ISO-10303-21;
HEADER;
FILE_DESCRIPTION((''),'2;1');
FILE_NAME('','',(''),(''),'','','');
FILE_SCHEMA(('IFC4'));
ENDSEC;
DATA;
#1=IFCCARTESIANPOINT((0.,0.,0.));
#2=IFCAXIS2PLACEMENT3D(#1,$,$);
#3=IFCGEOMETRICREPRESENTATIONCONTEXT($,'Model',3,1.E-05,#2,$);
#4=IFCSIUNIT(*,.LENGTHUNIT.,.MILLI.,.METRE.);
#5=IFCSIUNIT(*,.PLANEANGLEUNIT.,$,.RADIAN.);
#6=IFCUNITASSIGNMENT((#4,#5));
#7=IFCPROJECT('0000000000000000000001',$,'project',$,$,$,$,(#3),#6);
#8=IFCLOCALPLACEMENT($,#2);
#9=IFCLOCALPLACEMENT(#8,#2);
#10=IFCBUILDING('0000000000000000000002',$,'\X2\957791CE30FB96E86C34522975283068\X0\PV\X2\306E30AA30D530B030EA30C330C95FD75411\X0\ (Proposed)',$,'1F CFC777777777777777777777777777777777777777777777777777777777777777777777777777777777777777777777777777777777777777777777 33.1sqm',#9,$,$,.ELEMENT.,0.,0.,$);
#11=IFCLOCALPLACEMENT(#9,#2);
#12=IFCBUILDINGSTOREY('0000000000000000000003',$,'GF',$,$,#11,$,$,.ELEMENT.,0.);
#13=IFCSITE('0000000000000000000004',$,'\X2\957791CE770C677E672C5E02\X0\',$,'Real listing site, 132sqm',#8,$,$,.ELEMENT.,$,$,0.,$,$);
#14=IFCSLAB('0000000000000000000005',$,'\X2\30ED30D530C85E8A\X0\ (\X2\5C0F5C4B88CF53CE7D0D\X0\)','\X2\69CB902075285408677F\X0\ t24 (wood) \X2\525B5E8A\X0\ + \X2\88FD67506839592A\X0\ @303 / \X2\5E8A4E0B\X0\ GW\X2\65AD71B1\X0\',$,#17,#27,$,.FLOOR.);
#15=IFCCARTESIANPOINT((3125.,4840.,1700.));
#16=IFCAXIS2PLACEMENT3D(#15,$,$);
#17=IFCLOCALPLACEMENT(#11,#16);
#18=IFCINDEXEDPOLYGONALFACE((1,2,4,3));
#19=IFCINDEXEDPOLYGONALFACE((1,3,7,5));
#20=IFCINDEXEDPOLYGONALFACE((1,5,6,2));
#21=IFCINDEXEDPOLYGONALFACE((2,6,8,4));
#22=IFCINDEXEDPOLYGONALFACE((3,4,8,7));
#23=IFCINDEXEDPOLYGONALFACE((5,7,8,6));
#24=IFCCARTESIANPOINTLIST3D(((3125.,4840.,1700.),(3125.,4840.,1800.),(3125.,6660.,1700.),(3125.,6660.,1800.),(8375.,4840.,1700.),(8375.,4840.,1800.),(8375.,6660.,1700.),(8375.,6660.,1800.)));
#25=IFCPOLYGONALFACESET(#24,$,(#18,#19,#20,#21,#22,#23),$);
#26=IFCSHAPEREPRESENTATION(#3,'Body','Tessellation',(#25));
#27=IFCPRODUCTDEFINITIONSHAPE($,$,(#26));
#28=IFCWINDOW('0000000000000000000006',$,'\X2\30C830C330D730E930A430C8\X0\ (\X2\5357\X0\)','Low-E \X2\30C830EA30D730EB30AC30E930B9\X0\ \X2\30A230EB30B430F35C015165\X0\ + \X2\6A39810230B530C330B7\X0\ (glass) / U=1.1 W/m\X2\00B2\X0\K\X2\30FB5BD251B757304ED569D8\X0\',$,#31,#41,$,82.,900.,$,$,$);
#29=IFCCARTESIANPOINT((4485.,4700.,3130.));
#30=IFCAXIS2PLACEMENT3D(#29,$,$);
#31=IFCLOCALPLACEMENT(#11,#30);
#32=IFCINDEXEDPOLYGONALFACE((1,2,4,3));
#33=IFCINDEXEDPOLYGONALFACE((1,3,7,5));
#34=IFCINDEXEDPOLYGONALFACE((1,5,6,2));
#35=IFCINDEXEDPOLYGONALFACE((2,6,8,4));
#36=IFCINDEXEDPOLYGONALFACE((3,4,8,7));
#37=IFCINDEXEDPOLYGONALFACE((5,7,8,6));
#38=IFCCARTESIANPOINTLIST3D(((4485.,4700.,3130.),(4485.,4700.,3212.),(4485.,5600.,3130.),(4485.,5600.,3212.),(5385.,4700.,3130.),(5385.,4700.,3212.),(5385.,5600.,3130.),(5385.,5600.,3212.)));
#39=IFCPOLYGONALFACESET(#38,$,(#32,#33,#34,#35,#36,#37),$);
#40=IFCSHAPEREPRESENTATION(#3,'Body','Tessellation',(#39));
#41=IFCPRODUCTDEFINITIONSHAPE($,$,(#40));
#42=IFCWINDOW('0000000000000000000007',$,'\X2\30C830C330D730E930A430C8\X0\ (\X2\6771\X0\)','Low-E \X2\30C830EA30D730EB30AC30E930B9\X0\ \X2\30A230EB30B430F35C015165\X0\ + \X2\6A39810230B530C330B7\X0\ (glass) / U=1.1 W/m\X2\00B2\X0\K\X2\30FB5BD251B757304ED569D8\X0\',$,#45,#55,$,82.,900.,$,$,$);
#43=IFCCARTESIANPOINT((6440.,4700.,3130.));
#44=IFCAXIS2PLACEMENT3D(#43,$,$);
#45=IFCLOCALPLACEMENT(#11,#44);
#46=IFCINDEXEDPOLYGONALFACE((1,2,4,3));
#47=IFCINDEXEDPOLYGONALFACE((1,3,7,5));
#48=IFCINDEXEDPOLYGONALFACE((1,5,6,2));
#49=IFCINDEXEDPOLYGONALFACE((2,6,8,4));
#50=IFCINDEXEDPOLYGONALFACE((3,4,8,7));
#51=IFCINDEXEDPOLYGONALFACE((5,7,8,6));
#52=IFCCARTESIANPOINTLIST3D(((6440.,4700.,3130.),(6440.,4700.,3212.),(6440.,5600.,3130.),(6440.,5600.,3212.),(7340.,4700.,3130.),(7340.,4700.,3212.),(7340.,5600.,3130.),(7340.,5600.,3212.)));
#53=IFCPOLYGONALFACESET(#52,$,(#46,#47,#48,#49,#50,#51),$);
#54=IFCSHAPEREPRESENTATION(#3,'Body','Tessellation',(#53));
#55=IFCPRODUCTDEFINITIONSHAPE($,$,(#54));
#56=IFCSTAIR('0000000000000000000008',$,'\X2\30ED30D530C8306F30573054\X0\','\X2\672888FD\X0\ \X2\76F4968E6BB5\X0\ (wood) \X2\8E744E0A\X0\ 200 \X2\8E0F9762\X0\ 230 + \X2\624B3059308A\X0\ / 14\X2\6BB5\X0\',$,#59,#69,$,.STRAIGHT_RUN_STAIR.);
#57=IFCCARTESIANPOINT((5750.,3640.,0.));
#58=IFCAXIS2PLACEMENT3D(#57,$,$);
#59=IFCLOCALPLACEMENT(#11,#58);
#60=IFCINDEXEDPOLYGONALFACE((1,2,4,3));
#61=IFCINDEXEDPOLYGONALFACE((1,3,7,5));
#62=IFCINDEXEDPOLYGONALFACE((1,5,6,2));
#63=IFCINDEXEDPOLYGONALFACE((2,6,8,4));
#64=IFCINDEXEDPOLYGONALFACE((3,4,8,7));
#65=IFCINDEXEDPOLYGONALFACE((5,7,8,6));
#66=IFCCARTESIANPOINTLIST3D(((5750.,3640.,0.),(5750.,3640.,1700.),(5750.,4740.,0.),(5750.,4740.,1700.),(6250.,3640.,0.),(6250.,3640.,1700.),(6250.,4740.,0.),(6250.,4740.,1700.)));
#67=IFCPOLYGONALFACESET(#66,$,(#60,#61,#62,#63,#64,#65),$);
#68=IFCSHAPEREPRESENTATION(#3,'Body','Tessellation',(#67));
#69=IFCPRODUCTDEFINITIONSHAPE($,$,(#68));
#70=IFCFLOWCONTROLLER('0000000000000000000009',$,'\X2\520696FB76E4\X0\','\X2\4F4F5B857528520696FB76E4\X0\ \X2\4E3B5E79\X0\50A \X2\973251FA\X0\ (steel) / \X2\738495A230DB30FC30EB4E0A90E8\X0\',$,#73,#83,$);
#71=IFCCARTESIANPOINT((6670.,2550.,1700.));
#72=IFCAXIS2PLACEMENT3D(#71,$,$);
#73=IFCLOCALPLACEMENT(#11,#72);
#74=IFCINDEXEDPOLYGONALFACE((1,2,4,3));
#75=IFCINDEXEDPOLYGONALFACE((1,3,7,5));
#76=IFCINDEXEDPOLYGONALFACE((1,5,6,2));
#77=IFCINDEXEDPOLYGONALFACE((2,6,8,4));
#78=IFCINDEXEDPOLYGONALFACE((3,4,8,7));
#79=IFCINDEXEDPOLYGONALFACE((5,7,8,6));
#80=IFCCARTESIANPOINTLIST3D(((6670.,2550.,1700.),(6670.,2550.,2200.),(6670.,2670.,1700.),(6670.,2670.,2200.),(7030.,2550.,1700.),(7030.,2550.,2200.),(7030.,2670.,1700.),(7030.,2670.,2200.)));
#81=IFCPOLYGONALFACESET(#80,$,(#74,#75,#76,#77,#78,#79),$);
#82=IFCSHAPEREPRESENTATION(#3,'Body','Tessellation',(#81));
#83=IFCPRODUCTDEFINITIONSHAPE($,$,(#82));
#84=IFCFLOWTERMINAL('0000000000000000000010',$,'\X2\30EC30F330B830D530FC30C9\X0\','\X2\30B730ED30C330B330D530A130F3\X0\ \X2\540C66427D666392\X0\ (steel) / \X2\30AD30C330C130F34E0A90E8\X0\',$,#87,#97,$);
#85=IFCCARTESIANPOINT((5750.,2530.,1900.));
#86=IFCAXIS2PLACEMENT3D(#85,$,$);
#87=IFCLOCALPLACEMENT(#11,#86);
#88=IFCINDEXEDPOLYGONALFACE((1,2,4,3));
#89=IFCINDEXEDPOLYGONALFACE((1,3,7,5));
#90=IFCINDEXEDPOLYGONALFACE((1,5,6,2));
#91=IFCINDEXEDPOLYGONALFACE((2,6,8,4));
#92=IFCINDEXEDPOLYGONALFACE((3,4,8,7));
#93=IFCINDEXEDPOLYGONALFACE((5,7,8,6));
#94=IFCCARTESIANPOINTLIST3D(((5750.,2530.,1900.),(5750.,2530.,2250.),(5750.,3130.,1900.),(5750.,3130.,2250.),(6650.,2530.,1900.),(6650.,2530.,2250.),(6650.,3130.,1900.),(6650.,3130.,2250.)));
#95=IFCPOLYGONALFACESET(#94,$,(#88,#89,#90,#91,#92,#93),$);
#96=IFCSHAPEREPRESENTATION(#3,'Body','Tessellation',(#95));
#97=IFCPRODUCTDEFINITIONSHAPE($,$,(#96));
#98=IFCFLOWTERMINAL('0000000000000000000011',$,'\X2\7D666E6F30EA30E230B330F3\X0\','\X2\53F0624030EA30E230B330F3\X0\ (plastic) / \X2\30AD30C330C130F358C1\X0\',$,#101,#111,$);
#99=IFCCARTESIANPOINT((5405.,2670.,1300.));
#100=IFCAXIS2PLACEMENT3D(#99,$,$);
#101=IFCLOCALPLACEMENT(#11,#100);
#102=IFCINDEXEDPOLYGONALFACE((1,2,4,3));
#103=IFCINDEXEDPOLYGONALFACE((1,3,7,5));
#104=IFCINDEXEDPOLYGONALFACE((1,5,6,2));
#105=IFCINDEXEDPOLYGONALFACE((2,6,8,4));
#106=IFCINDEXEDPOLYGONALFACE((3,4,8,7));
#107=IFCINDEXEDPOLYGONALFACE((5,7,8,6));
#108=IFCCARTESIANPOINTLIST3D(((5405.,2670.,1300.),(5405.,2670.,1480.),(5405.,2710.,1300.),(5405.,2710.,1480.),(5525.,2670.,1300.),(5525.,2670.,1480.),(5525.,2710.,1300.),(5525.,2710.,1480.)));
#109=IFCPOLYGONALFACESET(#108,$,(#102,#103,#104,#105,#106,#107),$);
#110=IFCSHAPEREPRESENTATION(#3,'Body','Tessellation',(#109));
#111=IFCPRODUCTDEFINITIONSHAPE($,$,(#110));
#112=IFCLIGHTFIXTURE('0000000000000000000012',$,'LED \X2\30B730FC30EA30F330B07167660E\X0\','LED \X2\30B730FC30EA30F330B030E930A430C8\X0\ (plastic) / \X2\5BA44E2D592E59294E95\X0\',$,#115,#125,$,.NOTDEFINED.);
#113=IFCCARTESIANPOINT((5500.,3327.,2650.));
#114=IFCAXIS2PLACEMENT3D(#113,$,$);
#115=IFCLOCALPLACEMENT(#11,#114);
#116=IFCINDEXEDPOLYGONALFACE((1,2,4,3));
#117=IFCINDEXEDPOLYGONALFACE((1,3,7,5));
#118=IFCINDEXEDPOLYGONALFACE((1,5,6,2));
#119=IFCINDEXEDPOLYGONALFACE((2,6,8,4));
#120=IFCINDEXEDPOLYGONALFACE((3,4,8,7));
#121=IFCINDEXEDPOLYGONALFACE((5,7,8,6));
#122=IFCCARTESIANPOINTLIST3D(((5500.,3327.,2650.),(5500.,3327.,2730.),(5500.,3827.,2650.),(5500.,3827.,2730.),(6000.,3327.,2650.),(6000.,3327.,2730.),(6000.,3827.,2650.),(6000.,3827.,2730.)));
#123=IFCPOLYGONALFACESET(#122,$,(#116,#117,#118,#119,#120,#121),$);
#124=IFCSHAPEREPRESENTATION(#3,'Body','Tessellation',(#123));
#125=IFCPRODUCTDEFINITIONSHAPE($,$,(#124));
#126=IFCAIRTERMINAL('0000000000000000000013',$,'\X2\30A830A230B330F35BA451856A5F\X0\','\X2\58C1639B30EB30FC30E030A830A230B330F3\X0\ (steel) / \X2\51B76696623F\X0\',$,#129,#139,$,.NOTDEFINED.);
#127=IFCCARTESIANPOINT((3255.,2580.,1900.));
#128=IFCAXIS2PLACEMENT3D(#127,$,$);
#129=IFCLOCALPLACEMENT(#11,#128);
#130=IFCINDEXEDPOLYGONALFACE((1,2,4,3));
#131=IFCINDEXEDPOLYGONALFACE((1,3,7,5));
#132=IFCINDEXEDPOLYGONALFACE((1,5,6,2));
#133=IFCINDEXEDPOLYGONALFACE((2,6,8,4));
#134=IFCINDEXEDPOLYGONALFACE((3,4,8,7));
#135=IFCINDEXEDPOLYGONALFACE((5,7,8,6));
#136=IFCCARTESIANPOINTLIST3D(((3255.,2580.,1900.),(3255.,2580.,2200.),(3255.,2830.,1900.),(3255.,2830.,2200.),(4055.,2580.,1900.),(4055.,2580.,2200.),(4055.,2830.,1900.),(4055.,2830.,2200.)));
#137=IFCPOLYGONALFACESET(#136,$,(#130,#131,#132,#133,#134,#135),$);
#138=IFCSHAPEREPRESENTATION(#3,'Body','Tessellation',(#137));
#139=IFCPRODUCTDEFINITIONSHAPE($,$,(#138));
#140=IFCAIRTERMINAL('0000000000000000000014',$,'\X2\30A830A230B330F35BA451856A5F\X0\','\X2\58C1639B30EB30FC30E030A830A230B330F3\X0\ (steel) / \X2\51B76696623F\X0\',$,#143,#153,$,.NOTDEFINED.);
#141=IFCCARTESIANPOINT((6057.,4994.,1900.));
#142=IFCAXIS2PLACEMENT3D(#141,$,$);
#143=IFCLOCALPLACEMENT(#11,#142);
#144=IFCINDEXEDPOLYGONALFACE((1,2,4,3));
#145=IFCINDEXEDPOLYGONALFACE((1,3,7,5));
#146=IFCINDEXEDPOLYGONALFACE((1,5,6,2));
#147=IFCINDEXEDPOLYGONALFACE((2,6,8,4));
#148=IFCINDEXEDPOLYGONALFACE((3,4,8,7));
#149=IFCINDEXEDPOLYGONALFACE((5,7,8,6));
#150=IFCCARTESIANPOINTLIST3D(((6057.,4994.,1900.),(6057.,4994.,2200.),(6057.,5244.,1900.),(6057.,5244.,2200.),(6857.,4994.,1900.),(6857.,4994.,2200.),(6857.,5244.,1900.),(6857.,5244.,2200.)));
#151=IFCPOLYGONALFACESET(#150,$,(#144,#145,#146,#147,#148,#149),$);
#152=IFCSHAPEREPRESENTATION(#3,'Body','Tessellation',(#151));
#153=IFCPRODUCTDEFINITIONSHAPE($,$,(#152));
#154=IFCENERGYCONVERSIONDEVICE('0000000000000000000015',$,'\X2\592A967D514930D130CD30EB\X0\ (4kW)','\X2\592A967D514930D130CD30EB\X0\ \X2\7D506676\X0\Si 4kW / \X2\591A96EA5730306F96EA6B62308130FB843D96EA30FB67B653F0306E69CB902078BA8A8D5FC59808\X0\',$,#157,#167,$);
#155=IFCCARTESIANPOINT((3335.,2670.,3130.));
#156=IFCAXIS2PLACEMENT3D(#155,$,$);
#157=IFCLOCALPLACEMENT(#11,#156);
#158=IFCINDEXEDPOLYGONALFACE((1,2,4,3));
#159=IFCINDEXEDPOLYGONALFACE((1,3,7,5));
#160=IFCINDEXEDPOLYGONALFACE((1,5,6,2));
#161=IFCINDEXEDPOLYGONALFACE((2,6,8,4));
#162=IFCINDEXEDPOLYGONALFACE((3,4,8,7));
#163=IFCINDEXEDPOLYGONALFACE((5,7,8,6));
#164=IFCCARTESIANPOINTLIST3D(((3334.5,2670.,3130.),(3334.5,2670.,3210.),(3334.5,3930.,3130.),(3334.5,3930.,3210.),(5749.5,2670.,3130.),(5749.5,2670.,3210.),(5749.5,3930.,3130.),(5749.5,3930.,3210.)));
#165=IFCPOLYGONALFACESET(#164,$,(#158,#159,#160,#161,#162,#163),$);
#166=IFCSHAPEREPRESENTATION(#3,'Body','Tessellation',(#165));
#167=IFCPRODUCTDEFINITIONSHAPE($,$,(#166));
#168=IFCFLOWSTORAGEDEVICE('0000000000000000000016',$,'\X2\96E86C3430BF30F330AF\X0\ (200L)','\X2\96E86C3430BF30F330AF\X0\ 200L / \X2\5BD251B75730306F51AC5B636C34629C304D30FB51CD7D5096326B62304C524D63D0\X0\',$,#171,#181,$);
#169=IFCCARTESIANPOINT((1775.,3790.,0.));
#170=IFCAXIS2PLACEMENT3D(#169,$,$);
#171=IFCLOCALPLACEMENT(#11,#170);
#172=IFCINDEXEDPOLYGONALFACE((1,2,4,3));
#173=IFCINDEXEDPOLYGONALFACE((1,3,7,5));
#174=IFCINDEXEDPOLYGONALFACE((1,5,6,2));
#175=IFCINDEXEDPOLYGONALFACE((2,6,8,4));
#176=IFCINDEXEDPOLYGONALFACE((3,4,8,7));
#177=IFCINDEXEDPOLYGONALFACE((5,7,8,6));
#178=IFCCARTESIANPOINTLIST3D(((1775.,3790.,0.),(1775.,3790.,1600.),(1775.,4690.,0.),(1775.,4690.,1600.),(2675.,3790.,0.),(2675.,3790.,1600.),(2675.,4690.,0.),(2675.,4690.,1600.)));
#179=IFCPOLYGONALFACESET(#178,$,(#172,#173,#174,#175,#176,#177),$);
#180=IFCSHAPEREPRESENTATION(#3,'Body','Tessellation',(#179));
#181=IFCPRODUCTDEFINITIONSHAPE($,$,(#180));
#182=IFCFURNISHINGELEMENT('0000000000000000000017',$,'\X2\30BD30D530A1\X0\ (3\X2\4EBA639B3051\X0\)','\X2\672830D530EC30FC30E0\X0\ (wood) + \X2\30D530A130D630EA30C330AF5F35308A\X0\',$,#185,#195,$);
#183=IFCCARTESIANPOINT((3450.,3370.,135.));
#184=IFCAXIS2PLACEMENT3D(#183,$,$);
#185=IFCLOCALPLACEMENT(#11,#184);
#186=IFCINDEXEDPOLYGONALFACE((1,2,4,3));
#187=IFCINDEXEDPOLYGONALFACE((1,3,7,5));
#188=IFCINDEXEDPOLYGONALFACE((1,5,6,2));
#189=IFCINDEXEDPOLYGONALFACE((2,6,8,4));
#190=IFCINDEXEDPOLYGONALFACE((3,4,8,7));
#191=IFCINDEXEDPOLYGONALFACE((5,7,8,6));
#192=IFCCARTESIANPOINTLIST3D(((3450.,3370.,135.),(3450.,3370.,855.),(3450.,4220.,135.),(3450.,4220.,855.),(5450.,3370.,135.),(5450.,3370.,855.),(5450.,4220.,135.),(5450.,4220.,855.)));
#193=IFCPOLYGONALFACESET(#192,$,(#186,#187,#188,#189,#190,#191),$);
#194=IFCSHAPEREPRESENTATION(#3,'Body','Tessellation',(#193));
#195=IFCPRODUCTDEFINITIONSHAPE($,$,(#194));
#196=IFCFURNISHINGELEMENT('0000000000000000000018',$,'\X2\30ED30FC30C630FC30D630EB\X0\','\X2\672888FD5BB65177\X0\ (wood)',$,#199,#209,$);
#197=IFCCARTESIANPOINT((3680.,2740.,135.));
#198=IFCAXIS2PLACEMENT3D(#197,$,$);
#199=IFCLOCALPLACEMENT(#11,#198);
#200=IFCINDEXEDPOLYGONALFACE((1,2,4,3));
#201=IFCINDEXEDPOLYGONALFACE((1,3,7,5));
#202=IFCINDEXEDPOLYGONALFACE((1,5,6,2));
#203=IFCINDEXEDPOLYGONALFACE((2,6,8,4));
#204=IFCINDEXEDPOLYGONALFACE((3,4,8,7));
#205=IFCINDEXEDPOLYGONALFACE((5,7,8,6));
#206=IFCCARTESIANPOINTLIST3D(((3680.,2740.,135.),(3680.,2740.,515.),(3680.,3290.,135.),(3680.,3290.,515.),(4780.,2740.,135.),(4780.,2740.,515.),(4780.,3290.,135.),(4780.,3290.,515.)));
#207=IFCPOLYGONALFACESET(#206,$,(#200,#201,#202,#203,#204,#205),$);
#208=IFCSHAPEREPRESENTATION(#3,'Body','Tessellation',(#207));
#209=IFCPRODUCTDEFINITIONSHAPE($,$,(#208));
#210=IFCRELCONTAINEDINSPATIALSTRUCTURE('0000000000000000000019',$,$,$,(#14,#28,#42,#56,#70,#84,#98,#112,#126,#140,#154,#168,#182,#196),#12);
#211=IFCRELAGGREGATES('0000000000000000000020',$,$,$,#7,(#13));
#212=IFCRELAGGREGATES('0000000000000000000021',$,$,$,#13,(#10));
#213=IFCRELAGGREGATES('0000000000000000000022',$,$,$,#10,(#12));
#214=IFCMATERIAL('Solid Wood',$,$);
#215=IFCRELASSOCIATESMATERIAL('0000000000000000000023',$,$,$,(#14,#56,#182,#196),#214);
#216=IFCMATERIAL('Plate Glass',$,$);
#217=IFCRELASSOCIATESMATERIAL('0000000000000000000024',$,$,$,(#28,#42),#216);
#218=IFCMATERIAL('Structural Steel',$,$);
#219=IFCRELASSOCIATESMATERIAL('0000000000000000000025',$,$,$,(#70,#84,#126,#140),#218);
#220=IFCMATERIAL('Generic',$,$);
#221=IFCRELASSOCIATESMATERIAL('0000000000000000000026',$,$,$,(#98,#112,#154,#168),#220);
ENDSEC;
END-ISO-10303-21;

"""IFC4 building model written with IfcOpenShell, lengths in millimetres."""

from ifc_helpers import new_model, si_unit, frame, frame_2d, origin, place, context, project, spatial, rectangle, extrude, material, element, save


model = new_model("IFC4")

# Units and contexts
model_context = context("Model", 3, precision=1e-05, world=origin())
ifc_project = project(units=[si_unit("LENGTHUNIT", "METRE", prefix="MILLI"), si_unit("PLANEANGLEUNIT", "RADIAN")], contexts=[model_context])

# Site, building, storey
site_placement = place(None, origin())
site = spatial("IfcSite", under=ifc_project, at=site_placement, Name="長野県松本市", ObjectType="Real listing site, 132sqm", CompositionType="ELEMENT", RefElevation=0.0)
building_placement = place(site_placement, origin())
building = spatial("IfcBuilding", under=site, at=building_placement, Name="長野・雨水利用とPVのオフグリッド志向 (Proposed)", ObjectType="1F CFC777777777777777777777777777777777777777777777777777777777777777777777777777777777777777777777777777777777777777777777 33.1sqm", CompositionType="ELEMENT", ElevationOfRefHeight=0.0, ElevationOfTerrain=0.0)
storey_placement = place(building_placement, origin())
storey = spatial("IfcBuildingStorey", under=building, at=storey_placement, Name="GF", CompositionType="ELEMENT", Elevation=0.0)

# Shared definitions
ifc_material_1 = material(Name="Solid Wood")

# Slab
slab_placement = place(storey_placement, frame((3125.0, 4840.0, 1700.0)))
element("IfcSlab", 1, at=slab_placement, inside=storey, material=ifc_material_1, Name="ロフト床 (小屋裏収納)", Description="構造用合板 t24 (wood) 剛床 + 製材根太 @303 / 床下 GW断熱", PredefinedType="FLOOR", context=model_context, shape_type="SweptSolid", body=[
    extrude(rectangle(XDim=5250.0, YDim=1820.0, at=frame_2d((2625.0, 910.0))), frame((3125.0, 4840.0, 1700.0)), (0.0, 0.0, 1.0), 100.0),
])

# Windows
ifc_material_2 = material(Name="Plate Glass")
window_1_placement = place(storey_placement, frame((4485.0, 4700.0, 3130.0)))
element("IfcWindow", 2, at=window_1_placement, inside=storey, material=ifc_material_2, Name="トップライト (南)", Description="Low-E トリプルガラス アルゴン封入 + 樹脂サッシ (glass) / U=1.1 W/m²K・寒冷地仕様", OverallHeight=82.0, OverallWidth=900.0, context=model_context, shape_type="SweptSolid", body=[
    extrude(rectangle(XDim=900.0, YDim=900.0, at=frame_2d((450.0, 450.0))), frame((4485.0, 4700.0, 3130.0)), (0.0, 0.0, 1.0), 82.0),
])
window_2_placement = place(storey_placement, frame((6440.0, 4700.0, 3130.0)))
element("IfcWindow", 3, at=window_2_placement, inside=storey, material=ifc_material_2, Name="トップライト (東)", Description="Low-E トリプルガラス アルゴン封入 + 樹脂サッシ (glass) / U=1.1 W/m²K・寒冷地仕様", OverallHeight=82.0, OverallWidth=900.0, context=model_context, shape_type="SweptSolid", body=[
    extrude(rectangle(XDim=900.0, YDim=900.0, at=frame_2d((450.0, 450.0))), frame((6440.0, 4700.0, 3130.0)), (0.0, 0.0, 1.0), 82.0),
])

# Stair
stair_placement = place(storey_placement, frame((5750.0, 3640.0, 0.0)))
element("IfcStair", 4, at=stair_placement, inside=storey, material=ifc_material_1, Name="ロフトはしご", Description="木製 直階段 (wood) 蹴上 200 踏面 230 + 手すり / 14段", PredefinedType="STRAIGHT_RUN_STAIR", context=model_context, shape_type="SweptSolid", body=[
    extrude(rectangle(XDim=500.0, YDim=1100.0, at=frame_2d((250.0, 550.0))), frame((5750.0, 3640.0, 0.0)), (0.0, 0.0, 1.0), 1700.0),
])

# Flow controller
ifc_material_3 = material(Name="Structural Steel")
flow_controller_placement = place(storey_placement, frame((6670.0, 2550.0, 1700.0)))
element("IfcFlowController", 5, at=flow_controller_placement, inside=storey, material=ifc_material_3, Name="分電盤", Description="住宅用分電盤 主幹50A 露出 (steel) / 玄関ホール上部", context=model_context, shape_type="SweptSolid", body=[
    extrude(rectangle(XDim=360.0, YDim=120.0, at=frame_2d((180.0, 60.0))), frame((6670.0, 2550.0, 1700.0)), (0.0, 0.0, 1.0), 500.0),
])

# Flow terminals
flow_terminal_1_placement = place(storey_placement, frame((5750.0, 2530.0, 1900.0)))
element("IfcFlowTerminal", 6, at=flow_terminal_1_placement, inside=storey, material=ifc_material_3, Name="レンジフード", Description="シロッコファン 同時給排 (steel) / キッチン上部", context=model_context, shape_type="SweptSolid", body=[
    extrude(rectangle(XDim=900.0, YDim=600.0, at=frame_2d((450.0, 300.0))), frame((5750.0, 2530.0, 1900.0)), (0.0, 0.0, 1.0), 350.0),
])
ifc_material_4 = material(Name="Generic")
flow_terminal_2_placement = place(storey_placement, frame((5405.0, 2670.0, 1300.0)))
element("IfcFlowTerminal", 7, at=flow_terminal_2_placement, inside=storey, material=ifc_material_4, Name="給湯リモコン", Description="台所リモコン (plastic) / キッチン壁", context=model_context, shape_type="SweptSolid", body=[
    extrude(rectangle(XDim=120.0, YDim=40.0, at=frame_2d((60.0, 20.0))), frame((5405.0, 2670.0, 1300.0)), (0.0, 0.0, 1.0), 180.0),
])

# Light fixture
light_fixture_placement = place(storey_placement, frame((5500.0, 3327.0, 2650.0)))
element("IfcLightFixture", 8, at=light_fixture_placement, inside=storey, material=ifc_material_4, Name="LED シーリング照明", Description="LED シーリングライト (plastic) / 室中央天井", PredefinedType="NOTDEFINED", context=model_context, shape_type="SweptSolid", body=[
    extrude(rectangle(XDim=500.0, YDim=500.0, at=frame_2d((250.0, 250.0))), frame((5500.0, 3327.0, 2650.0)), (0.0, 0.0, 1.0), 80.0),
])

# Air terminals
air_terminal_1_placement = place(storey_placement, frame((3255.0, 2580.0, 1900.0)))
element("IfcAirTerminal", 9, at=air_terminal_1_placement, inside=storey, material=ifc_material_3, Name="エアコン室内機", Description="壁掛ルームエアコン (steel) / 冷暖房", PredefinedType="NOTDEFINED", context=model_context, shape_type="SweptSolid", body=[
    extrude(rectangle(XDim=800.0, YDim=250.0, at=frame_2d((400.0, 125.0))), frame((3255.0, 2580.0, 1900.0)), (0.0, 0.0, 1.0), 300.0),
])
air_terminal_2_placement = place(storey_placement, frame((6057.0, 4994.0, 1900.0)))
element("IfcAirTerminal", 10, at=air_terminal_2_placement, inside=storey, material=ifc_material_3, Name="エアコン室内機", Description="壁掛ルームエアコン (steel) / 冷暖房", PredefinedType="NOTDEFINED", context=model_context, shape_type="SweptSolid", body=[
    extrude(rectangle(XDim=800.0, YDim=250.0, at=frame_2d((400.0, 125.0))), frame((6057.0, 4994.0, 1900.0)), (0.0, 0.0, 1.0), 300.0),
])

# Energy conversion device
energy_conversion_device_placement = place(storey_placement, frame((3335.0, 2670.0, 3130.0)))
element("IfcEnergyConversionDevice", 11, at=energy_conversion_device_placement, inside=storey, material=ifc_material_4, Name="太陽光パネル (4kW)", Description="太陽光パネル 結晶Si 4kW / 多雪地は雪止め・落雪・架台の構造確認必須", context=model_context, shape_type="SweptSolid", body=[
    extrude(rectangle(XDim=2415.0, YDim=1260.0, at=frame_2d((1207.0, 630.0))), frame((3335.0, 2670.0, 3130.0)), (0.0, 0.0, 1.0), 80.0),
])

# Flow storage device
flow_storage_device_placement = place(storey_placement, frame((1775.0, 3790.0, 0.0)))
element("IfcFlowStorageDevice", 12, at=flow_storage_device_placement, inside=storey, material=ifc_material_4, Name="雨水タンク (200L)", Description="雨水タンク 200L / 寒冷地は冬季水抜き・凍結防止が前提", context=model_context, shape_type="SweptSolid", body=[
    extrude(rectangle(XDim=900.0, YDim=900.0, at=frame_2d((450.0, 450.0))), frame((1775.0, 3790.0, 0.0)), (0.0, 0.0, 1.0), 1600.0),
])

# Furnishing elements
furnishing_1_placement = place(storey_placement, frame((3450.0, 3370.0, 135.0)))
element("IfcFurnishingElement", 13, at=furnishing_1_placement, inside=storey, material=ifc_material_1, Name="ソファ (3人掛け)", Description="木フレーム (wood) + ファブリック張り", context=model_context, shape_type="SweptSolid", body=[
    extrude(rectangle(XDim=2000.0, YDim=850.0, at=frame_2d((1000.0, 425.0))), frame((3450.0, 3370.0, 135.0)), (0.0, 0.0, 1.0), 720.0),
])
furnishing_2_placement = place(storey_placement, frame((3680.0, 2740.0, 135.0)))
element("IfcFurnishingElement", 14, at=furnishing_2_placement, inside=storey, material=ifc_material_1, Name="ローテーブル", Description="木製家具 (wood)", context=model_context, shape_type="SweptSolid", body=[
    extrude(rectangle(XDim=1100.0, YDim=550.0, at=frame_2d((550.0, 275.0))), frame((3680.0, 2740.0, 135.0)), (0.0, 0.0, 1.0), 380.0),
])

save(model, "model.ifc")
